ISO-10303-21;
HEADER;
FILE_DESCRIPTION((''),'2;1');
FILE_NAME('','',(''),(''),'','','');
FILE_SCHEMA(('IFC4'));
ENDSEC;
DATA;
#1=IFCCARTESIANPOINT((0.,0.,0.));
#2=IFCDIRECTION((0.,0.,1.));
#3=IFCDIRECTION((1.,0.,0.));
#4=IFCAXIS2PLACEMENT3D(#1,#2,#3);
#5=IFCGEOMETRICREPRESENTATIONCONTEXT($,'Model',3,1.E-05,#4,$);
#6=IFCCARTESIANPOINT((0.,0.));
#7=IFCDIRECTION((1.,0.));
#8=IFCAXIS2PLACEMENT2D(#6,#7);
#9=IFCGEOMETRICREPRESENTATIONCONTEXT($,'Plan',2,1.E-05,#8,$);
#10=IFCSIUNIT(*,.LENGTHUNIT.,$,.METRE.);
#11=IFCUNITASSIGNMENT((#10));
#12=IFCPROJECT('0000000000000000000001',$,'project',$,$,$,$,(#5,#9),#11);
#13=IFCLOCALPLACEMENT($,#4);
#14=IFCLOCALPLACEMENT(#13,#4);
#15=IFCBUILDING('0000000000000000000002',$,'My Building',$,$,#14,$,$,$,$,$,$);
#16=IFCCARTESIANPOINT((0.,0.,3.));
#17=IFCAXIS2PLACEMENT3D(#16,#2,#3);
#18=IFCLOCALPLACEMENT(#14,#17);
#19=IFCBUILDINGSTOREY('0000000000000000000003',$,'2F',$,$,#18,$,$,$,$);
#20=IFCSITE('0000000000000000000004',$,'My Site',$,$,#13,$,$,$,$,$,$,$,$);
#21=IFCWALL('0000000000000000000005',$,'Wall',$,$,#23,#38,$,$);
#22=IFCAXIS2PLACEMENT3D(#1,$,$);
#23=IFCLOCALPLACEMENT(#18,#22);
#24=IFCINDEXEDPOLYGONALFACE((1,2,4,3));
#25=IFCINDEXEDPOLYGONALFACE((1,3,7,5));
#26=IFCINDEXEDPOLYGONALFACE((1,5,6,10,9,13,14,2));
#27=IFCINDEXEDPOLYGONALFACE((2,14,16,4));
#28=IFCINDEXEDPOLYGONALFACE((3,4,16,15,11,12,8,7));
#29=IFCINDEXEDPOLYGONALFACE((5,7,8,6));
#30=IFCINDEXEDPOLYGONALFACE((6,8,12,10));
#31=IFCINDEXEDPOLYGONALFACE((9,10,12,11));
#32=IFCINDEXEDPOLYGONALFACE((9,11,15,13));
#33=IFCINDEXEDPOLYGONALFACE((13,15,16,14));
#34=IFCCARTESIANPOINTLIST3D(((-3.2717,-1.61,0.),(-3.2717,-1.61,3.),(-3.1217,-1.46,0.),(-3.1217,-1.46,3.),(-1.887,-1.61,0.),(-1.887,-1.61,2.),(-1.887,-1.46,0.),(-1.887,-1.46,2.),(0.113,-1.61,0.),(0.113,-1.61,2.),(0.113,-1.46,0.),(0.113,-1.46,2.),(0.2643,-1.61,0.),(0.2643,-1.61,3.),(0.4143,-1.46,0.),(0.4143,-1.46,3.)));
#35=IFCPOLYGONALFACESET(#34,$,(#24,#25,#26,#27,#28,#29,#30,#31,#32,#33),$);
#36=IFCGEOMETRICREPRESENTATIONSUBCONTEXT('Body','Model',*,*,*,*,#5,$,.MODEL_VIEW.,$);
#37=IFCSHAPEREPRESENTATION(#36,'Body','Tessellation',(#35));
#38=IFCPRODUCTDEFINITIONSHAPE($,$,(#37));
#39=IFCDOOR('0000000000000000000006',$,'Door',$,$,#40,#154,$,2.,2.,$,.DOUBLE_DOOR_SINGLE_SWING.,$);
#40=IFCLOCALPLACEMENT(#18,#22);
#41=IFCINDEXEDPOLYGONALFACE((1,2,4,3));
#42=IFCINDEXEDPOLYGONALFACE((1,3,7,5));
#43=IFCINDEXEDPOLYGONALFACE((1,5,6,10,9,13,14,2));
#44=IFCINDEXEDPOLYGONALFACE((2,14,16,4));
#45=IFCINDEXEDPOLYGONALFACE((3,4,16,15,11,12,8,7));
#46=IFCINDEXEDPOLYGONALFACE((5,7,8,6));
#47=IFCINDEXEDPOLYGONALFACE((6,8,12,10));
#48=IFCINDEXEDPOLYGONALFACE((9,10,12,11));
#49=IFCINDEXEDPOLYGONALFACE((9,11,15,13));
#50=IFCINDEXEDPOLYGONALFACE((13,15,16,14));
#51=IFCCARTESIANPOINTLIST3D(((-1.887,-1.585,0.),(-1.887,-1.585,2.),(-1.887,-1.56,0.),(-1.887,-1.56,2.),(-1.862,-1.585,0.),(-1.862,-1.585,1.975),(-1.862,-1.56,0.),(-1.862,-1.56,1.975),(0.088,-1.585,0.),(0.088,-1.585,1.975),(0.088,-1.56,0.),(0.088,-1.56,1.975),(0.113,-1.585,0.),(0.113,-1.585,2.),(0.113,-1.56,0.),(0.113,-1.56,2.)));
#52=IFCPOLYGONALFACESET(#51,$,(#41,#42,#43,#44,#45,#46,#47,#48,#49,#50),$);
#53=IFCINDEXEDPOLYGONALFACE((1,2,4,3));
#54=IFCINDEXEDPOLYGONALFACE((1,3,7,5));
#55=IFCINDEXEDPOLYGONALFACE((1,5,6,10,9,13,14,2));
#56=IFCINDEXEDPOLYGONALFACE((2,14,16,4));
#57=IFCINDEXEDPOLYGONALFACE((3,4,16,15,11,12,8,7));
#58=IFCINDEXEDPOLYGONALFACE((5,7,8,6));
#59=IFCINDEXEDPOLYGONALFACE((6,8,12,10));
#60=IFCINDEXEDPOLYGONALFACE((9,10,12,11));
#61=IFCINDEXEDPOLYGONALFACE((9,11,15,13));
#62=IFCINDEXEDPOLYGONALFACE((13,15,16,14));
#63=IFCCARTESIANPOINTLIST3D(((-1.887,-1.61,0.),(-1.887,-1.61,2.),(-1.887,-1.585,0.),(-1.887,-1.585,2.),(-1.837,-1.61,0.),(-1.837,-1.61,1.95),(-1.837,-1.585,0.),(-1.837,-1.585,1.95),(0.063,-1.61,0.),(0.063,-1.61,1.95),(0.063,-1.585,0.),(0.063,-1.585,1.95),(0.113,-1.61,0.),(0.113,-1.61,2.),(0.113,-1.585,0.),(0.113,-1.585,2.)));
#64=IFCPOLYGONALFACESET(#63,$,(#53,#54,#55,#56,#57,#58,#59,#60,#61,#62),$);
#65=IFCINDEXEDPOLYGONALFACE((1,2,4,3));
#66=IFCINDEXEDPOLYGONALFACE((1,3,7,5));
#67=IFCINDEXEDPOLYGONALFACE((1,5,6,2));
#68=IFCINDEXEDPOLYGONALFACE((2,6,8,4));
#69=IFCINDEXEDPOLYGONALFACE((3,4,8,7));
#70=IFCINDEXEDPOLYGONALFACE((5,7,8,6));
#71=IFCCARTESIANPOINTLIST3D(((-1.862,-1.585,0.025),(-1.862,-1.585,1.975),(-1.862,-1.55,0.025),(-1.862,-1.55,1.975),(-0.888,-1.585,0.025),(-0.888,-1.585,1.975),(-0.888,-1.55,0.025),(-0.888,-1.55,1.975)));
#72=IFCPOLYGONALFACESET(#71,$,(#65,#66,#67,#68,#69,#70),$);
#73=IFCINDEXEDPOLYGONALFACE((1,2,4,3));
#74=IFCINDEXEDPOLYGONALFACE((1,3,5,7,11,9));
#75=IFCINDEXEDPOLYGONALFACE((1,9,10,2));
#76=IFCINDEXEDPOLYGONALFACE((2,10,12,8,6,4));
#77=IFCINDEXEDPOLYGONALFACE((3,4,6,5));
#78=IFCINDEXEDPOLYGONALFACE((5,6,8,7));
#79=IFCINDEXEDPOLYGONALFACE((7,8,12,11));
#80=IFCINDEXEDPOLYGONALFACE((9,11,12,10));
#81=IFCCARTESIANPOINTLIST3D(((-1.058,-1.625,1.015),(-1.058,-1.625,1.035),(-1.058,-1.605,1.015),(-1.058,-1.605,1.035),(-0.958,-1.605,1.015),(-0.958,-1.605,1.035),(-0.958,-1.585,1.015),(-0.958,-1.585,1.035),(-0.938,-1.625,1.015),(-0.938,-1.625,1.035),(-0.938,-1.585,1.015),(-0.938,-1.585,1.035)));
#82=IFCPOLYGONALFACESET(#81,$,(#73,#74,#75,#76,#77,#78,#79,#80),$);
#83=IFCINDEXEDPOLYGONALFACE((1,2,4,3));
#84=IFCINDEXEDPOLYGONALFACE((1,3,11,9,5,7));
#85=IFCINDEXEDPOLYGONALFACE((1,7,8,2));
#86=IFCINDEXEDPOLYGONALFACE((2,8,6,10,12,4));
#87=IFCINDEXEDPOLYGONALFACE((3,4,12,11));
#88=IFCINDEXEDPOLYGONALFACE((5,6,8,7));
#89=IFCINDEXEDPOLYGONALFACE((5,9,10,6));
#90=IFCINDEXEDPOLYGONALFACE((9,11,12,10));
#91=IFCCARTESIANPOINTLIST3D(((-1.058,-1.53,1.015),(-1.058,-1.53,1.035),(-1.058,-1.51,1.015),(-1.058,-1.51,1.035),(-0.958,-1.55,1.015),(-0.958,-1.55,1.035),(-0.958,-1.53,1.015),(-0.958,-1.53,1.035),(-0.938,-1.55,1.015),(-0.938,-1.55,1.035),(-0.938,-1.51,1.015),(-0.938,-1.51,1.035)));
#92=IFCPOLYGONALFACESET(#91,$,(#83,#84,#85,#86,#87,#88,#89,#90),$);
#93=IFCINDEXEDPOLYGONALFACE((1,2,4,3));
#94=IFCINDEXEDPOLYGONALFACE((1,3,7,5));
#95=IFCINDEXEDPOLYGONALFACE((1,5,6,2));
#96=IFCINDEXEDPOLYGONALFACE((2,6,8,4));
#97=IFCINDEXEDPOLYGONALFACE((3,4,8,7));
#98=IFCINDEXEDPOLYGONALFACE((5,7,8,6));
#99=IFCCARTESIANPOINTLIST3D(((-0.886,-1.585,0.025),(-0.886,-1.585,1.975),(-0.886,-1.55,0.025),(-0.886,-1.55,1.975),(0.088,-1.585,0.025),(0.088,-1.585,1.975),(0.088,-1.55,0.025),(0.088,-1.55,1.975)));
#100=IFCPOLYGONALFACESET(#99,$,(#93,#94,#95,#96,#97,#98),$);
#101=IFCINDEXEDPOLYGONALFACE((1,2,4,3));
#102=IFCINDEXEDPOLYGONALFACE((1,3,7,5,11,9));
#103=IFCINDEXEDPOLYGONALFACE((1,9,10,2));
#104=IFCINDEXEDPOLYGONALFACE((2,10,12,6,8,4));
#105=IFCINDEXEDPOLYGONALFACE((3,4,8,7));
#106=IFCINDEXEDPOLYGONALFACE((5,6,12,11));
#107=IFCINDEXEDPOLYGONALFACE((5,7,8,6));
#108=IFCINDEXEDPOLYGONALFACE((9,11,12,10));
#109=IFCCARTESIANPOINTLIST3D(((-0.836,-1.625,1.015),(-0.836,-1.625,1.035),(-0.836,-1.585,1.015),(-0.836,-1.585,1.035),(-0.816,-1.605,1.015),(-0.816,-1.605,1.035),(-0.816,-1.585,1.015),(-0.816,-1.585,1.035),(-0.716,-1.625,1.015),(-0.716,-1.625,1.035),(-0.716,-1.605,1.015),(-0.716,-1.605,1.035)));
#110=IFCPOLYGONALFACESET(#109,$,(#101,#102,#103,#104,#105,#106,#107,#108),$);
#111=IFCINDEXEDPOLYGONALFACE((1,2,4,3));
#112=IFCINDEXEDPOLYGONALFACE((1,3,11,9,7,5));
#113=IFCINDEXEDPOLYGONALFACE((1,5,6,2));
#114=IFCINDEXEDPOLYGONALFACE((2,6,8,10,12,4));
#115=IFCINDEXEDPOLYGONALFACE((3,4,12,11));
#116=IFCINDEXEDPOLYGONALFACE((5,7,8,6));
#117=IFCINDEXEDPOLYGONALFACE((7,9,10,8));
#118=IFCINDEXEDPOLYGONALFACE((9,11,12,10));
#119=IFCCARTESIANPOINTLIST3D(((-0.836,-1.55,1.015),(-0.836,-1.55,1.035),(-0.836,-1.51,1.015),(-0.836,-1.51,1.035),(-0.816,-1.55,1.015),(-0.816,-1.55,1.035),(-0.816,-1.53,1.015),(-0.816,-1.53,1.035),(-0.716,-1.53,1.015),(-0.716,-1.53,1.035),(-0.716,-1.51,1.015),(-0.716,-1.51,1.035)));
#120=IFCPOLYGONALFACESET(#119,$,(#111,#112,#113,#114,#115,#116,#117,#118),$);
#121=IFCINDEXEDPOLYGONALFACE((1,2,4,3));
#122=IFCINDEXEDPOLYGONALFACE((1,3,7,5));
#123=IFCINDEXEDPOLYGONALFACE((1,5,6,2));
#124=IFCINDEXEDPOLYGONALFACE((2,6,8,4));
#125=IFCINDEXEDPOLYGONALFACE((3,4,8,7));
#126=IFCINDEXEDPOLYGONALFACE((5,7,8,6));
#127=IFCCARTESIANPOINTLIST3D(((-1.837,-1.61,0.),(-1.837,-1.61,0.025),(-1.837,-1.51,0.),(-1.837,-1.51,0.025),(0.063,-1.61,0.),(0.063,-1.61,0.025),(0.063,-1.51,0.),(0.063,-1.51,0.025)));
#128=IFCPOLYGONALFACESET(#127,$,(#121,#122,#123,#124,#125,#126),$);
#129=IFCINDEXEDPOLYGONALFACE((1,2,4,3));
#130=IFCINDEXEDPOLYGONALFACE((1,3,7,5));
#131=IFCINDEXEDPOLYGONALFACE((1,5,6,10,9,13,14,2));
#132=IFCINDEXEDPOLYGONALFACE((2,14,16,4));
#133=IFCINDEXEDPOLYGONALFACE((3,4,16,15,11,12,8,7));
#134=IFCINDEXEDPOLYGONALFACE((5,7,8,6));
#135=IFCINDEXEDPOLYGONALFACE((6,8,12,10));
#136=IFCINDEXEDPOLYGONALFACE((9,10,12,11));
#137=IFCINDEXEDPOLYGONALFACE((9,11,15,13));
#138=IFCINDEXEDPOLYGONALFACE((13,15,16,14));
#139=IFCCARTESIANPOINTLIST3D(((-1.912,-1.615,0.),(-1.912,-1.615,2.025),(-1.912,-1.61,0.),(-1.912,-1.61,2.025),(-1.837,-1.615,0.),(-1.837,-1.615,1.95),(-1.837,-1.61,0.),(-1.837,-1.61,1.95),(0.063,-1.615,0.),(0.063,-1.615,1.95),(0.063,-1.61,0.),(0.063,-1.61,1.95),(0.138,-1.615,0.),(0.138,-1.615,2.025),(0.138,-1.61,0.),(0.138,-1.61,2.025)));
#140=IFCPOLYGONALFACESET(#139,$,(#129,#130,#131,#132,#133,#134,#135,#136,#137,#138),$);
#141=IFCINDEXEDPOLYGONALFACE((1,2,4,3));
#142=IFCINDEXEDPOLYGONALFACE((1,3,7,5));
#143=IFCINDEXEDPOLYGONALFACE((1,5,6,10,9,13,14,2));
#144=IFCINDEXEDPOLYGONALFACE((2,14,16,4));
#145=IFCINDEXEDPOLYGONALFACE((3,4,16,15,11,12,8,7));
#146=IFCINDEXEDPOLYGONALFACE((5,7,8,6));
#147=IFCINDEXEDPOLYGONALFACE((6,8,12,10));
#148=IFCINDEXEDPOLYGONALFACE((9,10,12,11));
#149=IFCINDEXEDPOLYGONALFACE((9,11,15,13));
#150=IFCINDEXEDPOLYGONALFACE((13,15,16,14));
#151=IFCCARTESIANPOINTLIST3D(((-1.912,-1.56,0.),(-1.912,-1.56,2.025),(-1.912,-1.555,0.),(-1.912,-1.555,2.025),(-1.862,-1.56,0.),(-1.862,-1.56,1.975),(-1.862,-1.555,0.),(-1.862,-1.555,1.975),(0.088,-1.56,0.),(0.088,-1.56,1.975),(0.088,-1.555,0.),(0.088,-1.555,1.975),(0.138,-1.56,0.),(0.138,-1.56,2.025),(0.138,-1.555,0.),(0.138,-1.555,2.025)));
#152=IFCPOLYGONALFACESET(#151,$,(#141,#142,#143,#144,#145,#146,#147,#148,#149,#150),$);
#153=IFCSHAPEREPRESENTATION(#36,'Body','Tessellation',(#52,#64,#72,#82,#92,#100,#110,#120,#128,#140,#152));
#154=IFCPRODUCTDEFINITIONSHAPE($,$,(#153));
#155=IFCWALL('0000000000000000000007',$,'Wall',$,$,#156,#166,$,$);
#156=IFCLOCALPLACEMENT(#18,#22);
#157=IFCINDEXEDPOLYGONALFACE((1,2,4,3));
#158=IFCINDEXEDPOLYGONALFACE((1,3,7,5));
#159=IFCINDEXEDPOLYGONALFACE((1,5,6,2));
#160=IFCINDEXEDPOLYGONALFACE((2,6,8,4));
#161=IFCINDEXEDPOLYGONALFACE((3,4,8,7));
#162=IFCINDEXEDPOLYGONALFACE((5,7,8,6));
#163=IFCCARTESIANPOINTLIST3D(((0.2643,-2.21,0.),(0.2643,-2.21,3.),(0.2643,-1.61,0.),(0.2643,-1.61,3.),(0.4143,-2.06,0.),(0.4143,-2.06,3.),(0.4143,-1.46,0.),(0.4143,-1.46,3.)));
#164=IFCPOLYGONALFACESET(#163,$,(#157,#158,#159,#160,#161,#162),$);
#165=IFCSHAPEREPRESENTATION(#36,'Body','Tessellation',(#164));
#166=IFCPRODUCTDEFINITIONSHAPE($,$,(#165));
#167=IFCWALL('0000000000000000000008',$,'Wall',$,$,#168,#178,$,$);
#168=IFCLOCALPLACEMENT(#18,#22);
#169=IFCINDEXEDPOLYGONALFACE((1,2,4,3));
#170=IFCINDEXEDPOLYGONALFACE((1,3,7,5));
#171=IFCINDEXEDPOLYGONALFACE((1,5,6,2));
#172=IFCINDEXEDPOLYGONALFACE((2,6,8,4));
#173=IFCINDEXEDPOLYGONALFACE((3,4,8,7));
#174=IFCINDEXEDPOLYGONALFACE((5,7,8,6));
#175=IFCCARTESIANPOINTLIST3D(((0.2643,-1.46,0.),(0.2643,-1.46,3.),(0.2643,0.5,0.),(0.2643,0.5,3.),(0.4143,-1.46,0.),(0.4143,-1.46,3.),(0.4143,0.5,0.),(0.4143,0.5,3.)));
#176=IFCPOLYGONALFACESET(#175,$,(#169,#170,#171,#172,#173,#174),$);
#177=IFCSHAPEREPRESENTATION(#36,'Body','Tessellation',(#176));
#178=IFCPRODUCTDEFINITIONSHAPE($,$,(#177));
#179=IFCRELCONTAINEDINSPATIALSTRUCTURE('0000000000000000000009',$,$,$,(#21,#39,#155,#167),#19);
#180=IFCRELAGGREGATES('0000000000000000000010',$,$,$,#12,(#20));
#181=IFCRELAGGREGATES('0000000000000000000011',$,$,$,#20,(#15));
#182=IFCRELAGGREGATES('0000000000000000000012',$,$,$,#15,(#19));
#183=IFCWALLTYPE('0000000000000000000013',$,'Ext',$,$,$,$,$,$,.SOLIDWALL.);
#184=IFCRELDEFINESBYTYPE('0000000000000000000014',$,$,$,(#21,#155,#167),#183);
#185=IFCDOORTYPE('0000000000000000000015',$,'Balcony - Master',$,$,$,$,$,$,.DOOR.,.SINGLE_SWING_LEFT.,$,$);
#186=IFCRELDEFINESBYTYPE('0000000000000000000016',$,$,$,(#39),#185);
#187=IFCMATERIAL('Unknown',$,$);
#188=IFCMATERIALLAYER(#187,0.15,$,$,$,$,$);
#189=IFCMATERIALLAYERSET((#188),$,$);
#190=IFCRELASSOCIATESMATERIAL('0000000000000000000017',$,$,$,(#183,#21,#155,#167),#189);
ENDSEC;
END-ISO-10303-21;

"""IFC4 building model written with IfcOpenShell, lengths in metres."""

from ifc_helpers import new_model, entity, si_unit, frame, origin_with_axes, origin_2d_with_axis, place, context, subcontext, project, spatial, line, indexed_curve, outline, extrude, shape, source, transform, mapped, material, layer, layer_set, layer_usage, type_object, type_shapes, element, fill, save


model = new_model("IFC4")

# Units and contexts
model_context = context("Model", 3, precision=1e-05, world=origin_with_axes())
plan_context = context("Plan", 2, precision=1e-05, world=origin_2d_with_axis())
body_context_1 = subcontext(model_context, "Body", "Model", "MODEL_VIEW")
body_context_2 = subcontext(plan_context, "Body", "Plan", "PLAN_VIEW")
ifc_project = project(units=[si_unit("LENGTHUNIT", "METRE")], contexts=[model_context, plan_context])

# Site, building, storey
site_placement = place(None, origin_with_axes())
site = spatial("IfcSite", under=ifc_project, at=site_placement, Name="My Site")
building_placement = place(site_placement, origin_with_axes())
building = spatial("IfcBuilding", under=site, at=building_placement, Name="My Building")
storey_placement = place(building_placement, frame((0.0, 0.0, 3.0), z_axis=(0.0, 0.0, 1.0), x_axis=(1.0, 0.0, 0.0)))
storey = spatial("IfcBuildingStorey", under=building, at=storey_placement, Name="2F")

# Shared definitions
ifc_material = material(Name="Unknown")
ifc_layer_1 = layer(ifc_material, 0.15)
ifc_layer_set_1 = layer_set([ifc_layer_1])
wall_type_1 = type_object("IfcWallType", Name="Ext", PredefinedType="SOLIDWALL", material=ifc_layer_set_1)

# Wall, opening, door
ifc_layer_usage_1 = layer_usage(ifc_layer_set_1, "AXIS2", "POSITIVE", 0.0)
wall_1_placement = place(storey_placement, frame((-3.2717, -1.61, 0.0), z_axis=(0.0, 0.0, 1.0), x_axis=(1.0, 0.0, 0.0)))
wall_1 = element("IfcWall", 1, at=wall_1_placement, inside=storey, type_object=wall_type_1, material=ifc_layer_usage_1, Name="Wall", context=body_context_1, shape_type="SweptSolid", body=[
    extrude(outline(indexed_curve([(0.0, 0.0), (0.15, 0.15), (3.686, 0.15), (3.536, 0.0)], segments=[line(1, 2, 3, 4, 1)])), origin_with_axes(), (0.0, 0.0, 1.0), 3.0),
])
shared_shape_1 = source(origin_with_axes(), body_context_1, "Body", "SweptSolid", [
    extrude(outline(indexed_curve([(0.0, 0.0), (2.0, 0.0), (2.0, 2.0), (0.0, 2.0)], segments=[line(1, 2, 3, 4, 1)])), frame((0.0, -0.6, 0.0), z_axis=(0.0, -1.0, 0.0), x_axis=(1.0, 0.0, 0.0)), (0.0, 0.0, -1.0), 1.2),
])
opening_1_placement = place(wall_1_placement, frame((1.3847, 0.0, 0.0), z_axis=(0.0, 0.0, 1.0), x_axis=(1.0, 0.0, 0.0)))
opening_1 = element("IfcOpeningElement", 2, at=opening_1_placement, cuts=wall_1, PredefinedType="OPENING", context=body_context_1, shape_type="MappedRepresentation", body=[
    mapped(shared_shape_1, transform((0.0, 0.0, 0.0), x_axis=(1.0, 0.0, 0.0), y_axis=(0.0, 1.0, 0.0), z_axis=(0.0, 0.0, 1.0), scale=1.0)),
])
door_type_1 = type_object("IfcDoorType", Name="Balcony - Master", OperationType="SINGLE_SWING_LEFT", PredefinedType="DOOR")
shared_shape_2 = source(origin_with_axes(), body_context_1, "Body", "SweptSolid", [
    extrude(outline(indexed_curve([(0.0, 0.0), (0.0, 2.0), (2.0, 2.0), (2.0, 0.0), (1.975, 0.0), (1.975, 1.975), (0.025, 1.975), (0.025, 0.0)], segments=[line(1, 2, 3, 4, 5, 6, 7, 8, 1)])), frame((0.0, 0.025, 0.0), z_axis=(0.0, -1.0, 0.0), x_axis=(1.0, 0.0, 0.0)), (0.0, 0.0, -1.0), 0.025),
    extrude(outline(indexed_curve([(0.0, 0.0), (0.0, 2.0), (2.0, 2.0), (2.0, 0.0), (1.95, 0.0), (1.95, 1.95), (0.05, 1.95), (0.05, 0.0)], segments=[line(1, 2, 3, 4, 5, 6, 7, 8, 1)])), frame((0.0, 0.0, 0.0), z_axis=(0.0, -1.0, 0.0), x_axis=(1.0, 0.0, 0.0)), (0.0, 0.0, -1.0), 0.025),
    extrude(outline(indexed_curve([(0.0, 0.0), (0.974, 0.0), (0.974, 0.035), (0.0, 0.035)], segments=[line(1, 2, 3, 4, 1)])), frame((0.025, 0.025, 0.025), z_axis=(0.0, 0.0, 1.0), x_axis=(1.0, 0.0, 0.0)), (0.0, 0.0, 1.0), 1.95),
    extrude(outline(indexed_curve([(0.0, 0.0), (0.0, -0.04), (-0.12, -0.04), (-0.12, -0.02), (-0.02, -0.02), (-0.02, 0.0)], segments=[line(1, 2, 3, 4, 5, 6, 1)])), frame((0.949, 0.025, 1.015), z_axis=(0.0, 0.0, 1.0), x_axis=(1.0, 0.0, 0.0)), (0.0, 0.0, 1.0), 0.02),
    extrude(outline(indexed_curve([(0.0, 0.0), (0.0, 0.04), (-0.12, 0.04), (-0.12, 0.02), (-0.02, 0.02), (-0.02, 0.0)], segments=[line(1, 2, 3, 4, 5, 6, 1)])), frame((0.949, 0.06, 1.015), z_axis=(0.0, 0.0, 1.0), x_axis=(1.0, 0.0, 0.0)), (0.0, 0.0, 1.0), 0.02),
    extrude(outline(indexed_curve([(0.0, 0.0), (-0.974, 0.0), (-0.974, 0.035), (0.0, 0.035)], segments=[line(1, 2, 3, 4, 1)])), frame((1.975, 0.025, 0.025), z_axis=(0.0, 0.0, 1.0), x_axis=(1.0, 0.0, 0.0)), (0.0, 0.0, 1.0), 1.95),
    extrude(outline(indexed_curve([(0.0, 0.0), (0.0, -0.04), (0.12, -0.04), (0.12, -0.02), (0.02, -0.02), (0.02, 0.0)], segments=[line(1, 2, 3, 4, 5, 6, 1)])), frame((1.051, 0.025, 1.015), z_axis=(0.0, 0.0, 1.0), x_axis=(1.0, 0.0, 0.0)), (0.0, 0.0, 1.0), 0.02),
    extrude(outline(indexed_curve([(0.0, 0.0), (0.0, 0.04), (0.12, 0.04), (0.12, 0.02), (0.02, 0.02), (0.02, 0.0)], segments=[line(1, 2, 3, 4, 5, 6, 1)])), frame((1.051, 0.06, 1.015), z_axis=(0.0, 0.0, 1.0), x_axis=(1.0, 0.0, 0.0)), (0.0, 0.0, 1.0), 0.02),
    extrude(outline(indexed_curve([(0.0, 0.0), (1.9, 0.0), (1.9, 0.1), (0.0, 0.1)], segments=[line(1, 2, 3, 4, 1)])), frame((0.05, 0.0, 0.0), z_axis=(0.0, 0.0, 1.0), x_axis=(1.0, 0.0, 0.0)), (0.0, 0.0, 1.0), 0.025),
    extrude(outline(indexed_curve([(0.0, 0.0), (0.0, 2.025), (2.05, 2.025), (2.05, 0.0), (1.975, 0.0), (1.975, 1.95), (0.075, 1.95), (0.075, 0.0)], segments=[line(1, 2, 3, 4, 5, 6, 7, 8, 1)])), frame((-0.025, -0.005, 0.0), z_axis=(0.0, -1.0, 0.0), x_axis=(1.0, 0.0, 0.0)), (0.0, 0.0, -1.0), 0.005),
    extrude(outline(indexed_curve([(0.0, 0.0), (0.0, 2.025), (2.05, 2.025), (2.05, 0.0), (2.0, 0.0), (2.0, 1.975), (0.05, 1.975), (0.05, 0.0)], segments=[line(1, 2, 3, 4, 5, 6, 7, 8, 1)])), frame((-0.025, 0.05, 0.0), z_axis=(0.0, -1.0, 0.0), x_axis=(1.0, 0.0, 0.0)), (0.0, 0.0, -1.0), 0.005),
])
shared_shape_3 = source(origin_with_axes(), body_context_2, "Body", "Curve2D", [
    entity("IfcIndexedPolyCurve", entity("IfcCartesianPointList2D", [[0.0, 0.0], [0.0, 0.05], [0.025, 0.05], [0.025, 0.025], [0.05, 0.025], [0.05, 0.0]]), [entity("IfcLineIndex", [1, 2, 3, 4, 5, 6, 1])]),
    entity("IfcIndexedPolyCurve", entity("IfcCartesianPointList2D", [[2.0, 0.0], [2.0, 0.05], [1.975, 0.05], [1.975, 0.025], [1.95, 0.025], [1.95, 0.0]]), [entity("IfcLineIndex", [1, 2, 3, 4, 5, 6, 1])]),
    entity("IfcTrimmedCurve", entity("IfcEllipse", entity("IfcAxis2Placement2D", entity("IfcCartesianPoint", [0.06, 0.05]), entity("IfcDirection", [1.0, 0.0])), 0.94, 0.975), [entity("IfcCartesianPoint", [1.0, 0.05])], [entity("IfcCartesianPoint", [0.06, 1.025])], True, "CARTESIAN"),
    entity("IfcIndexedPolyCurve", entity("IfcCartesianPointList2D", [[0.025, 0.05], [0.06, 0.05], [0.06, 1.025], [0.025, 1.025]]), [entity("IfcLineIndex", [1, 2, 3, 4, 1])]),
    entity("IfcTrimmedCurve", entity("IfcEllipse", entity("IfcAxis2Placement2D", entity("IfcCartesianPoint", [1.94, 0.05]), entity("IfcDirection", [1.0, 0.0])), 0.94, 0.975), [entity("IfcCartesianPoint", [1.94, 1.025])], [entity("IfcCartesianPoint", [1.0, 0.05])], True, "CARTESIAN"),
    entity("IfcIndexedPolyCurve", entity("IfcCartesianPointList2D", [[1.975, 0.05], [1.94, 0.05], [1.94, 1.025], [1.975, 1.025]]), [entity("IfcLineIndex", [1, 2, 3, 4, 1])]),
])
type_shapes(door_type_1, [shared_shape_2, shared_shape_3])
door_1_placement = place(opening_1_placement, frame((0.0, 0.0, 0.0), z_axis=(0.0, 0.0, 1.0), x_axis=(1.0, 0.0, 0.0)))
door_1 = element("IfcDoor", 3, at=door_1_placement, inside=storey, type_object=door_type_1, Name="Door", OperationType="DOUBLE_DOOR_SINGLE_SWING", OverallHeight=2.0, OverallWidth=2.0, shapes=[
    shape(body_context_1, "Body", "MappedRepresentation", [mapped(shared_shape_2, transform((0.0, 0.0, 0.0), x_axis=(1.0, 0.0, 0.0), y_axis=(0.0, 1.0, 0.0), z_axis=(0.0, 0.0, 1.0), scale=1.0))]),
    shape(body_context_2, "Body", "MappedRepresentation", [mapped(shared_shape_3, transform((0.0, 0.0, 0.0), x_axis=(1.0, 0.0, 0.0), y_axis=(0.0, 1.0, 0.0), z_axis=(0.0, 0.0, 1.0), scale=1.0))]),
])
fill(opening_1, door_1)

# Walls
ifc_layer_usage_2 = layer_usage(ifc_layer_set_1, "AXIS2", "POSITIVE", 0.0)
wall_2_placement = place(storey_placement, frame((0.2643, -1.61, 0.0), z_axis=(0.0, 0.0, 1.0), x_axis=(0.0, -1.0, 0.0)))
element("IfcWall", 4, at=wall_2_placement, inside=storey, type_object=wall_type_1, material=ifc_layer_usage_2, Name="Wall", context=body_context_1, shape_type="SweptSolid", body=[
    extrude(outline(indexed_curve([(0.0, 0.0), (-0.15, 0.15), (0.45, 0.15), (0.6, 0.0)], segments=[line(1, 2, 3, 4, 1)])), origin_with_axes(), (0.0, 0.0, 1.0), 3.0),
])
ifc_layer_usage_3 = layer_usage(ifc_layer_set_1, "AXIS2", "POSITIVE", 0.0)
wall_3_placement = place(storey_placement, frame((0.4143, -1.46, 0.0), z_axis=(0.0, 0.0, 1.0), x_axis=(0.0, 1.0, 0.0)))
element("IfcWall", 5, at=wall_3_placement, inside=storey, type_object=wall_type_1, material=ifc_layer_usage_3, Name="Wall", context=body_context_1, shape_type="SweptSolid", body=[
    extrude(outline(indexed_curve([(0.0, 0.0), (0.0, 0.15), (1.96, 0.15), (1.96, 0.0)], segments=[line(1, 2, 3, 4, 1)])), origin_with_axes(), (0.0, 0.0, 1.0), 3.0),
])

save(model, "model.ifc")
